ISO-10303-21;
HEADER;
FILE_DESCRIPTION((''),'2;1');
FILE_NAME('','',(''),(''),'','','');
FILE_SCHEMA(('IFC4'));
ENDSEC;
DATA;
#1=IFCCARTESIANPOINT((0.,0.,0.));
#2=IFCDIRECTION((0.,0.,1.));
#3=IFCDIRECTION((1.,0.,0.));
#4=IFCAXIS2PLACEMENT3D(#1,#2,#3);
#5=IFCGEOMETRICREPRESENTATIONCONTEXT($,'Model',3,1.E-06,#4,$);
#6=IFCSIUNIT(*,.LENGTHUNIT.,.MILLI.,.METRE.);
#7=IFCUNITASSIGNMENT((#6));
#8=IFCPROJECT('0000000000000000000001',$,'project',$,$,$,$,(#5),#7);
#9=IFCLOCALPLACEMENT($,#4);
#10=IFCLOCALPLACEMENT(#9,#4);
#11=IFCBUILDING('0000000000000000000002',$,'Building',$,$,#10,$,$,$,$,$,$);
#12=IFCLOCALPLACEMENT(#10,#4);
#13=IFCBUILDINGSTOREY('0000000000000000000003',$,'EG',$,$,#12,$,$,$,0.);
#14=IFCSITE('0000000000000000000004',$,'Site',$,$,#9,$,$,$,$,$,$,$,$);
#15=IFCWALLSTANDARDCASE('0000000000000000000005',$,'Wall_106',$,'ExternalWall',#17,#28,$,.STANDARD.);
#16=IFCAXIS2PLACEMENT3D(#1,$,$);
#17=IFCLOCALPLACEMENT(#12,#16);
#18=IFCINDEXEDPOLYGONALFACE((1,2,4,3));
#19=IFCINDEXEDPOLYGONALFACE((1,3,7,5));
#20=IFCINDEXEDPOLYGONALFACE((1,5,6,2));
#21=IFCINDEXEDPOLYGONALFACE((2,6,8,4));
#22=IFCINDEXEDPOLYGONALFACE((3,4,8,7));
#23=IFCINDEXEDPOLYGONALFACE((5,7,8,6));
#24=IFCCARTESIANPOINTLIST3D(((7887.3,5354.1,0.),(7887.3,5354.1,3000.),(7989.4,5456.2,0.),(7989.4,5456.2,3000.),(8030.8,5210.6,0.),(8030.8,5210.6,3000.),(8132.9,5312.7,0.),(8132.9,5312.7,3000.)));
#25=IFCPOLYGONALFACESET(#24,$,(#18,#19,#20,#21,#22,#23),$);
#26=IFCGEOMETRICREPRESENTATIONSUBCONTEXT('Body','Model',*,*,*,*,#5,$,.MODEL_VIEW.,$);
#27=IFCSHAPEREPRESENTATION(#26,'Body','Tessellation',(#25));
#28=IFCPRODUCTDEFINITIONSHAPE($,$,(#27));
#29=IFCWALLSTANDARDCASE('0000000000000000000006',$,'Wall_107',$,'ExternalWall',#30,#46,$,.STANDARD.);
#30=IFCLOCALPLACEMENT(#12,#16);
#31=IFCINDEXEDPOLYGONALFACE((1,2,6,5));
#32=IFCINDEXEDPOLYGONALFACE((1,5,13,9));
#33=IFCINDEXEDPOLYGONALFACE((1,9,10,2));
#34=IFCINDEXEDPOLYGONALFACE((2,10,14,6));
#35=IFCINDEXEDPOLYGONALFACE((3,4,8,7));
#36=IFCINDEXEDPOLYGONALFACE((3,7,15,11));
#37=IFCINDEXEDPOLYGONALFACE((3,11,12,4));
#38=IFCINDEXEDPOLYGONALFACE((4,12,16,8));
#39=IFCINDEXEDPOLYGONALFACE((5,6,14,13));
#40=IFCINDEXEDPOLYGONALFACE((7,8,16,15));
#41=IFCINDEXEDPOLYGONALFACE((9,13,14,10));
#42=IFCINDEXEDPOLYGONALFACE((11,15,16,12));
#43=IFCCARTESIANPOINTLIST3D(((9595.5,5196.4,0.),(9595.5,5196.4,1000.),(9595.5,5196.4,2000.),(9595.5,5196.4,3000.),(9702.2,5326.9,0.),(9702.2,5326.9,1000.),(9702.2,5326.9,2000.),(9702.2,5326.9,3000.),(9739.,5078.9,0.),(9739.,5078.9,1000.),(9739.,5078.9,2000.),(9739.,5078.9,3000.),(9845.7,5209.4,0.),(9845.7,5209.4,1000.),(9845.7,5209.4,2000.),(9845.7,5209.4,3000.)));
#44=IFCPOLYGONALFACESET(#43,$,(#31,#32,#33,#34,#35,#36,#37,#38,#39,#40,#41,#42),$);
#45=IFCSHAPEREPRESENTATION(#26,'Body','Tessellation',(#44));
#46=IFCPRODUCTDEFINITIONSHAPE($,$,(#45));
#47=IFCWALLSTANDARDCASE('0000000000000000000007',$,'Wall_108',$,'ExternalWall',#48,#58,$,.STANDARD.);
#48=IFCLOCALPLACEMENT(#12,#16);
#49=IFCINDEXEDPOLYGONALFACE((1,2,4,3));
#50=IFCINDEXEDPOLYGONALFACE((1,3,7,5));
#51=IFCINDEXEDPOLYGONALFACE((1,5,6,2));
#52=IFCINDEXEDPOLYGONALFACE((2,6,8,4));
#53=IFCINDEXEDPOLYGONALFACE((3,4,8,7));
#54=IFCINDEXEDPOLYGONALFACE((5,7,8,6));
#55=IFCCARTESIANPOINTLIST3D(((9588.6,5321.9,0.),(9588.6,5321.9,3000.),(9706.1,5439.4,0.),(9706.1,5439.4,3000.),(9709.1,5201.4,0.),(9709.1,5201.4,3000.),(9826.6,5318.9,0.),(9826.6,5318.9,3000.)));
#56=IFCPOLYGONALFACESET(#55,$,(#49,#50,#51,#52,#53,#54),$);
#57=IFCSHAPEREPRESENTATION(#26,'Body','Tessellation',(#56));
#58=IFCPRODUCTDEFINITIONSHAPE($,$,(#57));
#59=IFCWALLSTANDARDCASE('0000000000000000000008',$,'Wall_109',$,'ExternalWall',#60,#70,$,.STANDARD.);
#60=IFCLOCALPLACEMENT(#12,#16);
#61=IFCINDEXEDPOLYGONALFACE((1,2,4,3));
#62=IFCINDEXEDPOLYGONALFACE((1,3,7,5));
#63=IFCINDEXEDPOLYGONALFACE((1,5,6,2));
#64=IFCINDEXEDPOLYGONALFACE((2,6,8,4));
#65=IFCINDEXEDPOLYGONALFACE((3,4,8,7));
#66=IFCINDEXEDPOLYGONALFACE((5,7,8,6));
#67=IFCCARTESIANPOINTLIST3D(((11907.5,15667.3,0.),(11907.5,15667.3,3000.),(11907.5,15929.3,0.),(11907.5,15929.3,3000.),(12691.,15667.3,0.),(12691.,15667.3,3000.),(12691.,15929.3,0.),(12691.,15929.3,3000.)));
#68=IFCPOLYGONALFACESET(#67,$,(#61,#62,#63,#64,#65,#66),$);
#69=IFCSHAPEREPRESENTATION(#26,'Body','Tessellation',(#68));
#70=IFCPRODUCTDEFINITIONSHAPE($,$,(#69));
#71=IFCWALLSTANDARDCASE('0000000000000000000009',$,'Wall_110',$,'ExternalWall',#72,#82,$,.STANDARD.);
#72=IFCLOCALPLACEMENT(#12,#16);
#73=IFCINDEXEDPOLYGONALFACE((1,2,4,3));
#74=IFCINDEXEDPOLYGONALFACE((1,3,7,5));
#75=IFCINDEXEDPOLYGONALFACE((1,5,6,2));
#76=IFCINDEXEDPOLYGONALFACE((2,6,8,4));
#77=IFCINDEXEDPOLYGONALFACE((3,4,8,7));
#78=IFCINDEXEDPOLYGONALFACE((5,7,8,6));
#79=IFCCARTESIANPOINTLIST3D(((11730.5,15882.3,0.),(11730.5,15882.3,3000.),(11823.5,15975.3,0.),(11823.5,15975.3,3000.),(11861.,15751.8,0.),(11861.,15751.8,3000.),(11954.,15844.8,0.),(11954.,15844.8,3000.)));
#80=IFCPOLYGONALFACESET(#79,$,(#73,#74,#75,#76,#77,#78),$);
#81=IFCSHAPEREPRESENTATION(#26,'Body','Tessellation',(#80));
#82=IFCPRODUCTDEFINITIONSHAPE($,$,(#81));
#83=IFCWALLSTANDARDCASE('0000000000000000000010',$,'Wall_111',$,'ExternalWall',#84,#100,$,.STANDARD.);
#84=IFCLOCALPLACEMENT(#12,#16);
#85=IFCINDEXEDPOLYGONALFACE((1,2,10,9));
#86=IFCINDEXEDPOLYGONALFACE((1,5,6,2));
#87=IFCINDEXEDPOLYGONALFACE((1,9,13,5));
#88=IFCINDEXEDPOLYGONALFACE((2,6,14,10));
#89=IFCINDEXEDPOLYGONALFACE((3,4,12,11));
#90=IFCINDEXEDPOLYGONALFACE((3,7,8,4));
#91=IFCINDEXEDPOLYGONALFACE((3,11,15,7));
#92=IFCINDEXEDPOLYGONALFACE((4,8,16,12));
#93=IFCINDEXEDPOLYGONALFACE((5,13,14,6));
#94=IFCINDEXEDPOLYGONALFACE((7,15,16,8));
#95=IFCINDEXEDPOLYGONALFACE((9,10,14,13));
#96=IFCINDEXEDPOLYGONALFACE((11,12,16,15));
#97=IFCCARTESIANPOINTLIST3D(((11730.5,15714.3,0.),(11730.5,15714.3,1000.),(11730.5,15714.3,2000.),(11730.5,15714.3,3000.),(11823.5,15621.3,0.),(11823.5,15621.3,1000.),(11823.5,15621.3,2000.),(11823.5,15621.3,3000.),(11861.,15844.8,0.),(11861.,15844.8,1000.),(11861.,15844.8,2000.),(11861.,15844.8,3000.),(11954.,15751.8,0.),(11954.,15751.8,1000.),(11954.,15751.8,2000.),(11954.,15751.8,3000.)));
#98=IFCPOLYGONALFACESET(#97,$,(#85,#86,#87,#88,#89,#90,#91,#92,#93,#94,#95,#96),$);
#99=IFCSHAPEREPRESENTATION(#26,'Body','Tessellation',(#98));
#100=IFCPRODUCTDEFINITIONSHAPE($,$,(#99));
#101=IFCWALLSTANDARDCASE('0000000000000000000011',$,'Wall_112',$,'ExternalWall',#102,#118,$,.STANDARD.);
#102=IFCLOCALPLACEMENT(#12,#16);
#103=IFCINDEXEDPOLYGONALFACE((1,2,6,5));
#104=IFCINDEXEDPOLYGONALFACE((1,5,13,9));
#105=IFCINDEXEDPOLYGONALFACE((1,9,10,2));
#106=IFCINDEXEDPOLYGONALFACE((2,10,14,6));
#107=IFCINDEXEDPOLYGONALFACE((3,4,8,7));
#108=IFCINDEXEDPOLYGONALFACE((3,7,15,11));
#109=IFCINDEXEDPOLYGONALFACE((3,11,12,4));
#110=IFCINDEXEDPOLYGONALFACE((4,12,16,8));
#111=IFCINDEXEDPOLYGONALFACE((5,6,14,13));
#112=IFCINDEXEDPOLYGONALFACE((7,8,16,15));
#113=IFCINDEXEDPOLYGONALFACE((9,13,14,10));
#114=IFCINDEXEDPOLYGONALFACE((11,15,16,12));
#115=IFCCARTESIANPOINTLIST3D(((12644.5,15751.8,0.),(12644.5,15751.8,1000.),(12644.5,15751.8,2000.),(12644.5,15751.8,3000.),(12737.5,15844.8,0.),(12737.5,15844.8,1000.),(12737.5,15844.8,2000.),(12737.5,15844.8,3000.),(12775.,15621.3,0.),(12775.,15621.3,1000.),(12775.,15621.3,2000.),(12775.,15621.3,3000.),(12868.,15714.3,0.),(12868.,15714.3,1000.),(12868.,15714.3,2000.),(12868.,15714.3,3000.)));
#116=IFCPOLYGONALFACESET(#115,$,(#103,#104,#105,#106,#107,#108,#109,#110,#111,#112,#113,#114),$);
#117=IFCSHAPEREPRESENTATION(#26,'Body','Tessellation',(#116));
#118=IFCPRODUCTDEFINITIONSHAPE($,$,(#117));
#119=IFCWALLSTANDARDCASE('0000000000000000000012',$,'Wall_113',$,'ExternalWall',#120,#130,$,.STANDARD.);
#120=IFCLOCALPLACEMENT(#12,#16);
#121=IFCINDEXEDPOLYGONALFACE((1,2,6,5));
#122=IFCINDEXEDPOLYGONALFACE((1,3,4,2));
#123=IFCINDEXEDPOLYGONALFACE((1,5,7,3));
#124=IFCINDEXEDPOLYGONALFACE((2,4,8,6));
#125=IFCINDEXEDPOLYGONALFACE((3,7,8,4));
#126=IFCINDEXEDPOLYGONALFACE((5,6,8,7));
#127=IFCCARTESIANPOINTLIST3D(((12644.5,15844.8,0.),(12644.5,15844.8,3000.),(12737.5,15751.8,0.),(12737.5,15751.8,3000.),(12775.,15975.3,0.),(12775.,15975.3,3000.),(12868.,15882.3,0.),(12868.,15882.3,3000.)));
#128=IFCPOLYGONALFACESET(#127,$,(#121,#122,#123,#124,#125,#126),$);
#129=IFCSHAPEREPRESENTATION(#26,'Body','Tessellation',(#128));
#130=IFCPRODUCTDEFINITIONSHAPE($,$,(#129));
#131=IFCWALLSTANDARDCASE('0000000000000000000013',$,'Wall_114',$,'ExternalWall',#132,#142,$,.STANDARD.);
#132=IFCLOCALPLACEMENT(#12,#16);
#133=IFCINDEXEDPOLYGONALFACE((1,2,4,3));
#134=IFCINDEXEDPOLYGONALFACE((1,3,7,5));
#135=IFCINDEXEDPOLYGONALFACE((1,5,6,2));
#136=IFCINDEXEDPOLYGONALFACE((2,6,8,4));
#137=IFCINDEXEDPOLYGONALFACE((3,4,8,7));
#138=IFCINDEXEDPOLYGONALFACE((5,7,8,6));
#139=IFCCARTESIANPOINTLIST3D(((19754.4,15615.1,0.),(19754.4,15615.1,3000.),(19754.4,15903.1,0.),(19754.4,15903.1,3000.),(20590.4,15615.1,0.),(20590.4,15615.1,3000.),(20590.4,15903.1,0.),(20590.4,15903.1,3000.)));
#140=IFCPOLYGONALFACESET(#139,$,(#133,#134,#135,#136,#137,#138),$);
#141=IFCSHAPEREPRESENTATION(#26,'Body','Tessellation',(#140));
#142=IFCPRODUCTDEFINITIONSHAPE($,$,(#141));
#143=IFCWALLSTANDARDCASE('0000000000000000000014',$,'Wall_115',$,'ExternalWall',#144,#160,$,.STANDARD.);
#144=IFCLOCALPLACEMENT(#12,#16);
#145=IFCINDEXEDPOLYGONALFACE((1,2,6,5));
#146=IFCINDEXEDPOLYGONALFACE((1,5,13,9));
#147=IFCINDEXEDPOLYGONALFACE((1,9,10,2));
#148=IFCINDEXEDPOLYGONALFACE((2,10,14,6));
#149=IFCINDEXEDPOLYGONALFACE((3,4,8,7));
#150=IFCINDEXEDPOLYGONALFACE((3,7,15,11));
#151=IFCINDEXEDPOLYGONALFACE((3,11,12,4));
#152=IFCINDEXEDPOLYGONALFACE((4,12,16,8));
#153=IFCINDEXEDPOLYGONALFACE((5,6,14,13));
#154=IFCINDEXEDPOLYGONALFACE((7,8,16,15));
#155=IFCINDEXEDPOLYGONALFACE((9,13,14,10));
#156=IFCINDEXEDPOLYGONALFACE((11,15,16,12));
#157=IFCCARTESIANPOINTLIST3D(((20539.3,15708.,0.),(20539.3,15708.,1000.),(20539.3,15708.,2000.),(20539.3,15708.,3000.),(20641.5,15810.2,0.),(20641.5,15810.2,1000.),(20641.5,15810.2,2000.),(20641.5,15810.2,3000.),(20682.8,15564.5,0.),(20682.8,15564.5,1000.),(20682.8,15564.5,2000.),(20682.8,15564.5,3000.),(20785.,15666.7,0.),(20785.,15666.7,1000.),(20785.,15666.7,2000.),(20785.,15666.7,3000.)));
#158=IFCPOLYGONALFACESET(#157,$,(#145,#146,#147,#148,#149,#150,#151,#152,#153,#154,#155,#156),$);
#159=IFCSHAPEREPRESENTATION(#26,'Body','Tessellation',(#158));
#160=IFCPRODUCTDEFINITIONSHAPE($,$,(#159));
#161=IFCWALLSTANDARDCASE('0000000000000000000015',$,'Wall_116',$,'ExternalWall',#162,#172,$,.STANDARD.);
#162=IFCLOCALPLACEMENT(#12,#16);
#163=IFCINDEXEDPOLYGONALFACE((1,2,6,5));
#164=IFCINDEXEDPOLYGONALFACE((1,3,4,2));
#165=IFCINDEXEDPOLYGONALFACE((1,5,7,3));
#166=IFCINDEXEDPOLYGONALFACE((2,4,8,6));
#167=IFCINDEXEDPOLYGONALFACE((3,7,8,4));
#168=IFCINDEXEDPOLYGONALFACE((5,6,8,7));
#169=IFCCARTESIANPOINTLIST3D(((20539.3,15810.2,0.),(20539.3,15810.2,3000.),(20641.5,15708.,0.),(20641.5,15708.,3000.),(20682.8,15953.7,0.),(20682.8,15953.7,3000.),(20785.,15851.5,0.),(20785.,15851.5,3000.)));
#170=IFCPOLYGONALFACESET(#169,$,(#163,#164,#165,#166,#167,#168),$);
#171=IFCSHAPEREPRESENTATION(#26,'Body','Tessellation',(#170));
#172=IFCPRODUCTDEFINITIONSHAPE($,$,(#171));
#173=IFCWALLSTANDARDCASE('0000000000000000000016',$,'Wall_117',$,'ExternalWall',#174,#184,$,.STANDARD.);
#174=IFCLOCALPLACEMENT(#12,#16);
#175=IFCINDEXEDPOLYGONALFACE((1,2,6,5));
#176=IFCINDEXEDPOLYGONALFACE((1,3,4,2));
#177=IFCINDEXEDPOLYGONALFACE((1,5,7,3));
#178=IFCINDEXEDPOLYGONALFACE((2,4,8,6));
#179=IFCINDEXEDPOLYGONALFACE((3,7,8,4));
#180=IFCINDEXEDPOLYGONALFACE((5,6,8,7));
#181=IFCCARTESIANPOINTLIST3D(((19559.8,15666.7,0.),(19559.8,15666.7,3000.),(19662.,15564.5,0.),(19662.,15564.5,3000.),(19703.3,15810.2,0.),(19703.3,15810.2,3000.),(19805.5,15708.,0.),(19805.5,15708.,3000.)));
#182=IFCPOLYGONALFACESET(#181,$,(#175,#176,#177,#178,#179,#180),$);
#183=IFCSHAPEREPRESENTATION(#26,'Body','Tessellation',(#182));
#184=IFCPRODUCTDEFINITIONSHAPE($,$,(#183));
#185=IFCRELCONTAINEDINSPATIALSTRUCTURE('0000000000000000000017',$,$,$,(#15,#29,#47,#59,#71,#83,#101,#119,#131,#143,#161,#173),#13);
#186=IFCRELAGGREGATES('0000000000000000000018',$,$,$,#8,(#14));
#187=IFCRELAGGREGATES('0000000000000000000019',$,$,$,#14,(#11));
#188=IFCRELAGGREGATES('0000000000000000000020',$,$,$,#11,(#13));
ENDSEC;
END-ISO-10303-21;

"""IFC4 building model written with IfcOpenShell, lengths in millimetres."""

from ifc_helpers import new_model, si_unit, frame, origin_with_axes, place, context, subcontext, project, spatial, rectangle, extrude, element, save


model = new_model("IFC4")

# Units and contexts
model_context = context("Model", 3, precision=1e-06, world=origin_with_axes())
body_context = subcontext(model_context, "Body", "Model", "MODEL_VIEW")
ifc_project = project(units=[si_unit("LENGTHUNIT", "METRE", prefix="MILLI")], contexts=[model_context])

# Site, building, storey
site_placement = place(None, origin_with_axes())
site = spatial("IfcSite", under=ifc_project, at=site_placement, Name="Site")
building_placement = place(site_placement, origin_with_axes())
building = spatial("IfcBuilding", under=site, at=building_placement, Name="Building")
storey_placement = place(building_placement, origin_with_axes())
storey = spatial("IfcBuildingStorey", under=building, at=storey_placement, Name="EG", Elevation=0.0)

# Wall
wall_1_placement = place(storey_placement, origin_with_axes())
element("IfcWallStandardCase", 1, at=wall_1_placement, inside=storey, Name="Wall_106", ObjectType="ExternalWall", PredefinedType="STANDARD", context=body_context, shape_type="SweptSolid", body=[
    extrude(rectangle(XDim=202.9, YDim=144.5), frame((8010.1, 5333.4, 0.0), z_axis=(0.0, 0.0, 1.0), x_axis=(-0.707107, 0.707107, 0.0)), (0.0, 0.0, 1.0), 3000.0),
])

# Wall, opening
wall_2_placement = place(storey_placement, origin_with_axes())
wall_2 = element("IfcWallStandardCase", 2, at=wall_2_placement, inside=storey, Name="Wall_107", ObjectType="ExternalWall", PredefinedType="STANDARD", context=body_context, shape_type="SweptSolid", body=[
    extrude(rectangle(XDim=185.5, YDim=168.5), frame((9720.6, 5202.9, 0.0), z_axis=(0.0, 0.0, 1.0), x_axis=(0.773717, -0.633531, 0.0)), (0.0, 0.0, 1.0), 3000.0),
])
opening_1_placement = place(wall_2_placement, origin_with_axes())
element("IfcOpeningElement", 3, at=opening_1_placement, inside=storey, cuts=wall_2, context=body_context, shape_type="SweptSolid", body=[
    extrude(rectangle(XDim=600.0, YDim=168.5), frame((9744.0, 5183.8, 1000.0), z_axis=(0.0, 0.0, 1.0), x_axis=(0.773717, -0.633531, 0.0)), (0.0, 0.0, 1.0), 1000.0),
])

# Walls
wall_3_placement = place(storey_placement, origin_with_axes())
element("IfcWallStandardCase", 4, at=wall_3_placement, inside=storey, Name="Wall_108", ObjectType="ExternalWall", PredefinedType="STANDARD", context=body_context, shape_type="SweptSolid", body=[
    extrude(rectangle(XDim=166.2, YDim=170.5), frame((9707.6, 5320.4, 0.0), z_axis=(0.0, 0.0, 1.0), x_axis=(0.707107, 0.707107, 0.0)), (0.0, 0.0, 1.0), 3000.0),
])
wall_4_placement = place(storey_placement, origin_with_axes())
element("IfcWallStandardCase", 5, at=wall_4_placement, inside=storey, Name="Wall_109", ObjectType="ExternalWall", PredefinedType="STANDARD", context=body_context, shape_type="SweptSolid", body=[
    extrude(rectangle(XDim=783.5, YDim=262.0), frame((12299.2, 15798.3, 0.0), z_axis=(0.0, 0.0, 1.0), x_axis=(1.0, 0.0, 0.0)), (0.0, 0.0, 1.0), 3000.0),
])
wall_5_placement = place(storey_placement, origin_with_axes())
element("IfcWallStandardCase", 6, at=wall_5_placement, inside=storey, Name="Wall_110", ObjectType="ExternalWall", PredefinedType="STANDARD", context=body_context, shape_type="SweptSolid", body=[
    extrude(rectangle(XDim=184.6, YDim=131.5), frame((11842.2, 15863.6, 0.0), z_axis=(0.0, 0.0, 1.0), x_axis=(0.707107, -0.707107, 0.0)), (0.0, 0.0, 1.0), 3000.0),
])

# Walls, openings
wall_6_placement = place(storey_placement, origin_with_axes())
wall_6 = element("IfcWallStandardCase", 7, at=wall_6_placement, inside=storey, Name="Wall_111", ObjectType="ExternalWall", PredefinedType="STANDARD", context=body_context, shape_type="SweptSolid", body=[
    extrude(rectangle(XDim=184.6, YDim=131.5), frame((11842.2, 15733.1, 0.0), z_axis=(0.0, 0.0, 1.0), x_axis=(-0.707107, -0.707107, 0.0)), (0.0, 0.0, 1.0), 3000.0),
])
opening_2_placement = place(wall_6_placement, origin_with_axes())
element("IfcOpeningElement", 8, at=opening_2_placement, inside=storey, cuts=wall_6, context=body_context, shape_type="SweptSolid", body=[
    extrude(rectangle(XDim=600.0, YDim=131.5), frame((11822.7, 15713.5, 1000.0), z_axis=(0.0, 0.0, 1.0), x_axis=(-0.707107, -0.707107, 0.0)), (0.0, 0.0, 1.0), 1000.0),
])
wall_7_placement = place(storey_placement, origin_with_axes())
wall_7 = element("IfcWallStandardCase", 9, at=wall_7_placement, inside=storey, Name="Wall_112", ObjectType="ExternalWall", PredefinedType="STANDARD", context=body_context, shape_type="SweptSolid", body=[
    extrude(rectangle(XDim=184.6, YDim=131.5), frame((12756.2, 15733.1, 0.0), z_axis=(0.0, 0.0, 1.0), x_axis=(0.707107, -0.707107, 0.0)), (0.0, 0.0, 1.0), 3000.0),
])
opening_3_placement = place(wall_7_placement, origin_with_axes())
element("IfcOpeningElement", 10, at=opening_3_placement, inside=storey, cuts=wall_7, context=body_context, shape_type="SweptSolid", body=[
    extrude(rectangle(XDim=600.0, YDim=131.5), frame((12756.2, 15733.1, 1000.0), z_axis=(0.0, 0.0, 1.0), x_axis=(0.707107, -0.707107, 0.0)), (0.0, 0.0, 1.0), 1000.0),
])

# Walls
wall_8_placement = place(storey_placement, origin_with_axes())
element("IfcWallStandardCase", 11, at=wall_8_placement, inside=storey, Name="Wall_113", ObjectType="ExternalWall", PredefinedType="STANDARD", context=body_context, shape_type="SweptSolid", body=[
    extrude(rectangle(XDim=184.6, YDim=131.5), frame((12756.2, 15863.6, 0.0), z_axis=(0.0, 0.0, 1.0), x_axis=(0.707107, 0.707107, 0.0)), (0.0, 0.0, 1.0), 3000.0),
])
wall_9_placement = place(storey_placement, origin_with_axes())
element("IfcWallStandardCase", 12, at=wall_9_placement, inside=storey, Name="Wall_114", ObjectType="ExternalWall", PredefinedType="STANDARD", context=body_context, shape_type="SweptSolid", body=[
    extrude(rectangle(XDim=836.0, YDim=288.0), frame((20172.4, 15759.1, 0.0), z_axis=(0.0, 0.0, 1.0), x_axis=(-1.0, 0.0, 0.0)), (0.0, 0.0, 1.0), 3000.0),
])

# Wall, opening
wall_10_placement = place(storey_placement, origin_with_axes())
wall_10 = element("IfcWallStandardCase", 13, at=wall_10_placement, inside=storey, Name="Wall_115", ObjectType="ExternalWall", PredefinedType="STANDARD", context=body_context, shape_type="SweptSolid", body=[
    extrude(rectangle(XDim=202.9, YDim=144.5), frame((20662.1, 15687.3, 0.0), z_axis=(0.0, 0.0, 1.0), x_axis=(0.707107, -0.707107, 0.0)), (0.0, 0.0, 1.0), 3000.0),
])
opening_4_placement = place(wall_10_placement, origin_with_axes())
element("IfcOpeningElement", 14, at=opening_4_placement, inside=storey, cuts=wall_10, context=body_context, shape_type="SweptSolid", body=[
    extrude(rectangle(XDim=600.0, YDim=144.5), frame((20668.6, 15680.9, 1000.0), z_axis=(0.0, 0.0, 1.0), x_axis=(0.707107, -0.707107, 0.0)), (0.0, 0.0, 1.0), 1000.0),
])

# Walls
wall_11_placement = place(storey_placement, origin_with_axes())
element("IfcWallStandardCase", 15, at=wall_11_placement, inside=storey, Name="Wall_116", ObjectType="ExternalWall", PredefinedType="STANDARD", context=body_context, shape_type="SweptSolid", body=[
    extrude(rectangle(XDim=202.9, YDim=144.5), frame((20662.1, 15830.8, 0.0), z_axis=(0.0, 0.0, 1.0), x_axis=(0.707107, 0.707107, 0.0)), (0.0, 0.0, 1.0), 3000.0),
])
wall_12_placement = place(storey_placement, origin_with_axes())
element("IfcWallStandardCase", 16, at=wall_12_placement, inside=storey, Name="Wall_117", ObjectType="ExternalWall", PredefinedType="STANDARD", context=body_context, shape_type="SweptSolid", body=[
    extrude(rectangle(XDim=202.9, YDim=144.5), frame((19682.6, 15687.3, 0.0), z_axis=(0.0, 0.0, 1.0), x_axis=(-0.707107, -0.707107, 0.0)), (0.0, 0.0, 1.0), 3000.0),
])

save(model, "model.ifc")
